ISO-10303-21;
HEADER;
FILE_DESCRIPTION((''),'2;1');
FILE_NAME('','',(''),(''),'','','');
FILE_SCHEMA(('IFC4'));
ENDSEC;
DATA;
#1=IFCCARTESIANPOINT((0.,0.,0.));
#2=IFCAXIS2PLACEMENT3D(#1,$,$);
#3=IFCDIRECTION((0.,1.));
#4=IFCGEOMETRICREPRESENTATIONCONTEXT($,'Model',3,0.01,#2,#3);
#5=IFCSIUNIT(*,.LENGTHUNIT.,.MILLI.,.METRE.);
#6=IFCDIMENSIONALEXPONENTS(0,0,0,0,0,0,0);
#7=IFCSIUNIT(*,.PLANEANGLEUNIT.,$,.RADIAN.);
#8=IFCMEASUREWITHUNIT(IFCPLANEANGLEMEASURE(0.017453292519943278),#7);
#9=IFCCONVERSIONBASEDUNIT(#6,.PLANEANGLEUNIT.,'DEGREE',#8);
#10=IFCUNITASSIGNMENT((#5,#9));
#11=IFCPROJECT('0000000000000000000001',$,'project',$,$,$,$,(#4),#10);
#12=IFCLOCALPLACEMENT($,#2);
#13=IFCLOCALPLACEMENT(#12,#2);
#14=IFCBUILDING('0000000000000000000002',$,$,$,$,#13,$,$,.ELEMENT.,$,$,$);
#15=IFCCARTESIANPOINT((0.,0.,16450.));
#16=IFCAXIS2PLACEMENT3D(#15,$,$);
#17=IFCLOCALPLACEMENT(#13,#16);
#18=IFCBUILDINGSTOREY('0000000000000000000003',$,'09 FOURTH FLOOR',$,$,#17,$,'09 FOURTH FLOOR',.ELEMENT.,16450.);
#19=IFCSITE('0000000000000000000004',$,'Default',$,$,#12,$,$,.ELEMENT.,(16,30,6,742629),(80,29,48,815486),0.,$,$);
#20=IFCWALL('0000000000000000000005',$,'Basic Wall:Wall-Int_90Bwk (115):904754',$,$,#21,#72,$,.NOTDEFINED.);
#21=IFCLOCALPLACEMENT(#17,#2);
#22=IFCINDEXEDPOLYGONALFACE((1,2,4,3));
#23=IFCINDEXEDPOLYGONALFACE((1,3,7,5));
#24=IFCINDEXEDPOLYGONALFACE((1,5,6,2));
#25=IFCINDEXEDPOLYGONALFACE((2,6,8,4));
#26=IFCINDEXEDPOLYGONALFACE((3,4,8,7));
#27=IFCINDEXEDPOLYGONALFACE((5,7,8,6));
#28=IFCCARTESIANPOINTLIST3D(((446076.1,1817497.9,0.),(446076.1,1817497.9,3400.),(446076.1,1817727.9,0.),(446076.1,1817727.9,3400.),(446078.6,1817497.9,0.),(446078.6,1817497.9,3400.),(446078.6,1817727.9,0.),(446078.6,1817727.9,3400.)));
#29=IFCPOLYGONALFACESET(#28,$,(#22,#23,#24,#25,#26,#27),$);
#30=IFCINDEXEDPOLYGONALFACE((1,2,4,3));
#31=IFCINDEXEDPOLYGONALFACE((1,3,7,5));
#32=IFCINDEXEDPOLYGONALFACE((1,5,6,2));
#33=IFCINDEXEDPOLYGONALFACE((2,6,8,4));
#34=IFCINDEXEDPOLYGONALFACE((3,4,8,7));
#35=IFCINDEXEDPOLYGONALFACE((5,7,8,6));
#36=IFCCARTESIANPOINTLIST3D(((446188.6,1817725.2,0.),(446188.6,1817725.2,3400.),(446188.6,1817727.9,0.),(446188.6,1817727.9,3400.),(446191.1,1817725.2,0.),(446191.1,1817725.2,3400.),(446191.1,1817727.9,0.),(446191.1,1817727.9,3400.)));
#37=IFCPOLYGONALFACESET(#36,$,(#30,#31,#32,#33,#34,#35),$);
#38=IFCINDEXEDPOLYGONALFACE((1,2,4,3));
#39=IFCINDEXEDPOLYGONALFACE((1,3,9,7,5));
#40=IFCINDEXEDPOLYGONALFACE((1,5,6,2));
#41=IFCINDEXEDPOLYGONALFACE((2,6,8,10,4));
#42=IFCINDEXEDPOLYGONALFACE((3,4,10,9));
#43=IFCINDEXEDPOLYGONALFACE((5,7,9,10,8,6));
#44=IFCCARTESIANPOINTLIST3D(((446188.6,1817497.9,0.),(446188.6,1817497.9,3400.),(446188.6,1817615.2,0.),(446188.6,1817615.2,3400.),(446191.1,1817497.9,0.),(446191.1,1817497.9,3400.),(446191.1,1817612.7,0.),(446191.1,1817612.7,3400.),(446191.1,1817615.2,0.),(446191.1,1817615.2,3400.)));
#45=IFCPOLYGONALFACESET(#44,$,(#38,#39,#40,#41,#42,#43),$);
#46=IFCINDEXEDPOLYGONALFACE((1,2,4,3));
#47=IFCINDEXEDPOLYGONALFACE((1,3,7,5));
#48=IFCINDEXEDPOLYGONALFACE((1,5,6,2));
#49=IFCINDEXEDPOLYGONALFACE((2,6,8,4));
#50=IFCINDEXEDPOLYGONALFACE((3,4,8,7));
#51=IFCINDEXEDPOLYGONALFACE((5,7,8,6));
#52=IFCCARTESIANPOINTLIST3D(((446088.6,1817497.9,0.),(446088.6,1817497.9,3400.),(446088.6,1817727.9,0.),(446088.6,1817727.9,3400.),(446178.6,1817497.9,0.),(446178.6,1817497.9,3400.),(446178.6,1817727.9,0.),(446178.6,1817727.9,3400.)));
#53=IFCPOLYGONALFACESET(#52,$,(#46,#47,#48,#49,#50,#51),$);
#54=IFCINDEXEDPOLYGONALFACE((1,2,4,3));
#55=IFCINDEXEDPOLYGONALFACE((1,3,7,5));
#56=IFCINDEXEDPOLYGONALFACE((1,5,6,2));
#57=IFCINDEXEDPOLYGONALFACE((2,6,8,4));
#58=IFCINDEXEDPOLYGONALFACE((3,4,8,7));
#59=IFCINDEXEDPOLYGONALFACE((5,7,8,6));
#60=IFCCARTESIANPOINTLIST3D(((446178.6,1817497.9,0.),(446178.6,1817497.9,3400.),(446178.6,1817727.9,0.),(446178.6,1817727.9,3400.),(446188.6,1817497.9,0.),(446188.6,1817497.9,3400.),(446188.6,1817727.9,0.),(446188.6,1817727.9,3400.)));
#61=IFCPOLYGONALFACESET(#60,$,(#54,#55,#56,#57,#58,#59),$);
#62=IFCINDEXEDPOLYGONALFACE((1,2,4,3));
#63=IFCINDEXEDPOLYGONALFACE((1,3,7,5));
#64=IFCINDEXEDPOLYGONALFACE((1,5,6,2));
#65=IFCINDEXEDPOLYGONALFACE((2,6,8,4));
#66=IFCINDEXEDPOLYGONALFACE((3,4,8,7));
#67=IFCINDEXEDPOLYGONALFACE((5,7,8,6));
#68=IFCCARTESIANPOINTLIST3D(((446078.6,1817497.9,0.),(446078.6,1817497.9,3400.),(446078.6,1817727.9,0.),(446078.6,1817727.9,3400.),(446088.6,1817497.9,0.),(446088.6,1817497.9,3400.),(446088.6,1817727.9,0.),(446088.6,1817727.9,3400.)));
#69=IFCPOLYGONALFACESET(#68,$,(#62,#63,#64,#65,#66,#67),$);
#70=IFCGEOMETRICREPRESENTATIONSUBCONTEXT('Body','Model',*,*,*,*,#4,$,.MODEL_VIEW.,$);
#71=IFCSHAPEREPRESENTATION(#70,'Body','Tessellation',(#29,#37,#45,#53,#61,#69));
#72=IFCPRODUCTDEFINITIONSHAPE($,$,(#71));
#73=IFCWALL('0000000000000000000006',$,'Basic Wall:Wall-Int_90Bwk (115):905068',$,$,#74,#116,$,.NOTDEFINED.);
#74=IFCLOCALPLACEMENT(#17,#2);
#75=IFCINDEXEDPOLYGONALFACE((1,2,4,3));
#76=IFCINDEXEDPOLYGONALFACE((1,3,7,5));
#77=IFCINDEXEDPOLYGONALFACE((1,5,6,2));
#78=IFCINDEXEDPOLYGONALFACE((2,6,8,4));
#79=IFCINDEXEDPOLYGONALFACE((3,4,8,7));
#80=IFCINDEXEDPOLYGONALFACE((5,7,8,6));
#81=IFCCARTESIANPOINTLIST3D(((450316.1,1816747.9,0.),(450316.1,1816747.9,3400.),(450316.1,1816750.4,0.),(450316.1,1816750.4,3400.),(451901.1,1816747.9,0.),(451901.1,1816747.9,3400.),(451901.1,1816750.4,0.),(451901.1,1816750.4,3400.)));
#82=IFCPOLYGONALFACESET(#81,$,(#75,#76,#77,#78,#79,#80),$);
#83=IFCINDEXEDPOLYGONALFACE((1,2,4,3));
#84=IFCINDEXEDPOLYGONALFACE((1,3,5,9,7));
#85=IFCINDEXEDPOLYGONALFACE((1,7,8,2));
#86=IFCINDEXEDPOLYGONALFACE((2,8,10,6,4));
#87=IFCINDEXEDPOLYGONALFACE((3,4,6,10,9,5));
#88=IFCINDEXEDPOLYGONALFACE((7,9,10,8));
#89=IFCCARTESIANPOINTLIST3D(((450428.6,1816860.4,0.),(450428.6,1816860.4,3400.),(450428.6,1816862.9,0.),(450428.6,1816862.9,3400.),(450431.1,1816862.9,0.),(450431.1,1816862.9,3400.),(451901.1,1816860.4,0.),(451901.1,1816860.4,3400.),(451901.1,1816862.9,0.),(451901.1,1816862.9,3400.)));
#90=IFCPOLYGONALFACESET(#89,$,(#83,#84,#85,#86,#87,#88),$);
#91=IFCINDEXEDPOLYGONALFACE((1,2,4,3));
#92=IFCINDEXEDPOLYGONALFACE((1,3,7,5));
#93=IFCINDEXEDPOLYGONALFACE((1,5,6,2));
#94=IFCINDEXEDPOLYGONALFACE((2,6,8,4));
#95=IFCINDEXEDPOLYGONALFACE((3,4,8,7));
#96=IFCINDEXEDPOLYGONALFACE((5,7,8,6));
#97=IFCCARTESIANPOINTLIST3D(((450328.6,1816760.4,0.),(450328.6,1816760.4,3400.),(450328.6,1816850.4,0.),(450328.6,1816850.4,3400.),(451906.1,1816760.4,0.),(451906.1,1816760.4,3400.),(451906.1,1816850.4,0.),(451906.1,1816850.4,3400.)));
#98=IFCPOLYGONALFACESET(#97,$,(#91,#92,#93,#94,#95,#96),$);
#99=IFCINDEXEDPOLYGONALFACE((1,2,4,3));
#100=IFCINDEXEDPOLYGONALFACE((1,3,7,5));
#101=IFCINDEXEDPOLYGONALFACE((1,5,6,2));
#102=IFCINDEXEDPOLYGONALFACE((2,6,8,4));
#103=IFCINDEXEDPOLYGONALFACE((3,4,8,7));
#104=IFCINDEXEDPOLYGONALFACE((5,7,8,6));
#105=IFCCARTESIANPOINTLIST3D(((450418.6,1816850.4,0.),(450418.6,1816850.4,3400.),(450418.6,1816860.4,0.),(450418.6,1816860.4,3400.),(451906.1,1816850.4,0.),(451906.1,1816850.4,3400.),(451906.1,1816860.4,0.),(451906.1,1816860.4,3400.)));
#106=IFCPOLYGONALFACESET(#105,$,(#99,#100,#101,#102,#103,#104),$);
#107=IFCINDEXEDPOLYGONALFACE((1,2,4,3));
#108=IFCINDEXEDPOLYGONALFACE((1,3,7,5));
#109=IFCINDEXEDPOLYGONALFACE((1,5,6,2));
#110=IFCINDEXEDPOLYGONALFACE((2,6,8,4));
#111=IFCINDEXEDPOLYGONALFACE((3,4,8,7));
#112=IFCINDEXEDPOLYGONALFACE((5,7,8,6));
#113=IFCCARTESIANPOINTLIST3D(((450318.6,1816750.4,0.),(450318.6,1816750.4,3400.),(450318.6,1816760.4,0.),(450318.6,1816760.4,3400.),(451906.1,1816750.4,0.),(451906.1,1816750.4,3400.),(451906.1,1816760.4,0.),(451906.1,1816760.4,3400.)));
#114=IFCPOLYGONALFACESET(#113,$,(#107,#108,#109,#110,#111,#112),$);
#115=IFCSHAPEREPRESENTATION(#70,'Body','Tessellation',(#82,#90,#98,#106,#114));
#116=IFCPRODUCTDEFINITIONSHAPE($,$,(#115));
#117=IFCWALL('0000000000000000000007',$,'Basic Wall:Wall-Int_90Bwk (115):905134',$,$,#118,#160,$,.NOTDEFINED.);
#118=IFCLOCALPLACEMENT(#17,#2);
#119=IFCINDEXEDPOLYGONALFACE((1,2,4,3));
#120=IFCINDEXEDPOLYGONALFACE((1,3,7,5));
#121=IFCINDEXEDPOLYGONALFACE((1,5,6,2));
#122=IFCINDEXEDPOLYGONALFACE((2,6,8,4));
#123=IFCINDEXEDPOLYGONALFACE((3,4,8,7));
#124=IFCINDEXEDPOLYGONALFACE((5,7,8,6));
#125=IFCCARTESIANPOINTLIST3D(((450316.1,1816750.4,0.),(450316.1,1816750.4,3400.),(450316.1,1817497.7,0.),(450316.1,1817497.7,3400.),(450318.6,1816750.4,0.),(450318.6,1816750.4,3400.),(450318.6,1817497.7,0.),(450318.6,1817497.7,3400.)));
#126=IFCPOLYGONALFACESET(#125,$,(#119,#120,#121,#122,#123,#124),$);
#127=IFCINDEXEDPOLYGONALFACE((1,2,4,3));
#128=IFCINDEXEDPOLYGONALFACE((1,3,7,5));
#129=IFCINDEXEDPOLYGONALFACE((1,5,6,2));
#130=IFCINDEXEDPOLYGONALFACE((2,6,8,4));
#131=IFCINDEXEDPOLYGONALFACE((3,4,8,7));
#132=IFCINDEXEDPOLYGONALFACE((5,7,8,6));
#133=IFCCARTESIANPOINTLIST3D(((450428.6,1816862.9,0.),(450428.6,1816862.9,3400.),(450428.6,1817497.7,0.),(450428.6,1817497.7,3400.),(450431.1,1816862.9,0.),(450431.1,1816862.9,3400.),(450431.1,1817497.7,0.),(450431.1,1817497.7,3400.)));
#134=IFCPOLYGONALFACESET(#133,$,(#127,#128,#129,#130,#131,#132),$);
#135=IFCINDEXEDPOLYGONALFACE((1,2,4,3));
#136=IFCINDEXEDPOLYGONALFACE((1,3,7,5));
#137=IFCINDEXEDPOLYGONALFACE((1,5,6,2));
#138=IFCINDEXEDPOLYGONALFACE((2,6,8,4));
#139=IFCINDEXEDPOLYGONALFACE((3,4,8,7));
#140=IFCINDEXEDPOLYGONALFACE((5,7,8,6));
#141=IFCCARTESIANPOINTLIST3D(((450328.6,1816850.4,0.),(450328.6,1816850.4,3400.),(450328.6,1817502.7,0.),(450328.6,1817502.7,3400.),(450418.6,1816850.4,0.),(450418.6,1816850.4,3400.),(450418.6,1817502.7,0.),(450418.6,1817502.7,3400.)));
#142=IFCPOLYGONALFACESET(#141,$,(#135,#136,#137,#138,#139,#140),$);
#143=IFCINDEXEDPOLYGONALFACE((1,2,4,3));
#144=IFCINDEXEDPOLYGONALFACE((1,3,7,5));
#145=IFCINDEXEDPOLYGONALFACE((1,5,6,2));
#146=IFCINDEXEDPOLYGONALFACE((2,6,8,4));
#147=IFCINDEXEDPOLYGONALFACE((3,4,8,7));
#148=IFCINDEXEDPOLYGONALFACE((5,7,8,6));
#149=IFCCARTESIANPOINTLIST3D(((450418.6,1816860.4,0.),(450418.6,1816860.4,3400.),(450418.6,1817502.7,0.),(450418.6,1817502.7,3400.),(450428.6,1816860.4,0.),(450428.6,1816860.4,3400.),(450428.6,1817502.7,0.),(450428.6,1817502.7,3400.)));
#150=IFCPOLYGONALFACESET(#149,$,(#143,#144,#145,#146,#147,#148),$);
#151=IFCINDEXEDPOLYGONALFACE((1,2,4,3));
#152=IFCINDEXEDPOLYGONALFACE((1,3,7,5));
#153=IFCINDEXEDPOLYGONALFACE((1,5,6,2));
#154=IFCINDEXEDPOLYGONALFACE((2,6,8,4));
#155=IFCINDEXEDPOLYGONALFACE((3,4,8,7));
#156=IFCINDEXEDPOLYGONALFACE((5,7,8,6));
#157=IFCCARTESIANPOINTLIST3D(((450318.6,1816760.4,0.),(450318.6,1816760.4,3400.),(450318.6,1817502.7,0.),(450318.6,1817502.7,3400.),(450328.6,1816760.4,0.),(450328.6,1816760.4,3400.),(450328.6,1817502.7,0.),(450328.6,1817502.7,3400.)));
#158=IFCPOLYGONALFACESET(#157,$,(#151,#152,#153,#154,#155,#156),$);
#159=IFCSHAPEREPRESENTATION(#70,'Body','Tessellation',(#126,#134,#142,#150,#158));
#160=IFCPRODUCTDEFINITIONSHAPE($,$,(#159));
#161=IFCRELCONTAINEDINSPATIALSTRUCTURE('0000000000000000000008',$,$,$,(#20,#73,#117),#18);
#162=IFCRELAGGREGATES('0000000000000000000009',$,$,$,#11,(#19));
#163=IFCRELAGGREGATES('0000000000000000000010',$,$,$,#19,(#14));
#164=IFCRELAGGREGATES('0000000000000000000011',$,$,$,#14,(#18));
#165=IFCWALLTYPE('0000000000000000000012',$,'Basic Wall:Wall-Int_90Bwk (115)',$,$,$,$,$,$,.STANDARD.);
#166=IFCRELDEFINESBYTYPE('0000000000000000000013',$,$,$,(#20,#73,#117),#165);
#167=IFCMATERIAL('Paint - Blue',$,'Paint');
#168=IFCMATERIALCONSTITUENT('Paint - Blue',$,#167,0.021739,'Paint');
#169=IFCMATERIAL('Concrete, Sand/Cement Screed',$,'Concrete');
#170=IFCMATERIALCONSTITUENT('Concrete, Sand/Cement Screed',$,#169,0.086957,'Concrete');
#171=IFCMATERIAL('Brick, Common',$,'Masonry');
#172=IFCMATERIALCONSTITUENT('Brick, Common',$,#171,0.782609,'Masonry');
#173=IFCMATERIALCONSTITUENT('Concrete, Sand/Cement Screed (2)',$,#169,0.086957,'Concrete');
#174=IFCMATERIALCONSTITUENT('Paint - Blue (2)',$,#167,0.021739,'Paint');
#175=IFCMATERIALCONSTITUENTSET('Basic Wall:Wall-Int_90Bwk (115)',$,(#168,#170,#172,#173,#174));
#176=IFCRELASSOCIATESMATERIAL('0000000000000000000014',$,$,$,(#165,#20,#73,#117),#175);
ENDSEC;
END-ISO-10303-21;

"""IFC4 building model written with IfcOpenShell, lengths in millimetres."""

from ifc_helpers import new_model, entity, si_unit, converted_unit, direction, frame, origin, place, context, subcontext, project, spatial, indexed_curve, outline, extrude, material, constituent, constituent_set, type_object, element, save


model = new_model("IFC4")

# Units and contexts
model_context = context("Model", 3, precision=0.01, world=origin(), true_north=direction((0.0, 1.0)))
body_context = subcontext(model_context, "Body", "Model", "MODEL_VIEW")
ifc_project = project(units=[si_unit("LENGTHUNIT", "METRE", prefix="MILLI"), converted_unit("PLANEANGLEUNIT", "DEGREE", entity("IfcPlaneAngleMeasure", 0.017453292519943278), si_unit("PLANEANGLEUNIT", "RADIAN"), dimensions=[0, 0, 0, 0, 0, 0, 0])], contexts=[model_context])

# Site, building, storey
site_placement = place(None, origin())
site = spatial("IfcSite", under=ifc_project, at=site_placement, Name="Default", CompositionType="ELEMENT", RefLatitude=(16, 30, 6, 742629), RefLongitude=(80, 29, 48, 815486), RefElevation=0.0)
building_placement = place(site_placement, origin())
building = spatial("IfcBuilding", under=site, at=building_placement, CompositionType="ELEMENT")
storey_placement = place(building_placement, frame((0.0, 0.0, 16450.0)))
storey = spatial("IfcBuildingStorey", under=building, at=storey_placement, Name="09 FOURTH FLOOR", LongName="09 FOURTH FLOOR", CompositionType="ELEMENT", Elevation=16450.0)

# Shared definitions
ifc_material_1 = material(Name="Paint - Blue", Category="Paint")
ifc_constituent_1 = constituent(ifc_material_1, Name="Paint - Blue", Category="Paint", fraction=0.021739)
ifc_material_2 = material(Name="Concrete, Sand/Cement Screed", Category="Concrete")
ifc_constituent_2 = constituent(ifc_material_2, Name="Concrete, Sand/Cement Screed", Category="Concrete", fraction=0.086957)
ifc_material_3 = material(Name="Brick, Common", Category="Masonry")
ifc_constituent_3 = constituent(ifc_material_3, Name="Brick, Common", Category="Masonry", fraction=0.782609)
ifc_constituent_4 = constituent(ifc_material_2, Name="Concrete, Sand/Cement Screed (2)", Category="Concrete", fraction=0.086957)
ifc_constituent_5 = constituent(ifc_material_1, Name="Paint - Blue (2)", Category="Paint", fraction=0.021739)
ifc_constituent_set_1 = constituent_set(constituents=[ifc_constituent_1, ifc_constituent_2, ifc_constituent_3, ifc_constituent_4, ifc_constituent_5], Name="Basic Wall:Wall-Int_90Bwk (115)")
wall_type_1 = type_object("IfcWallType", Name="Basic Wall:Wall-Int_90Bwk (115)", PredefinedType="STANDARD", material=ifc_constituent_set_1)

# Walls
wall_1_placement = place(storey_placement, frame((446133.6, 1817497.9, 0.0), z_axis=(0.0, 0.0, 1.0), x_axis=(0.0, 1.0, 0.0)))
element("IfcWall", 1, at=wall_1_placement, inside=storey, type_object=wall_type_1, material=ifc_constituent_set_1, Name="Basic Wall:Wall-Int_90Bwk (115):904754", PredefinedType="NOTDEFINED", context=body_context, shape_type="SweptSolid", body=[
    extrude(outline(indexed_curve([(-1.2, -115.0), (1.3, -115.0), (1.3, 115.0), (-1.2, 115.0), (-1.2, -115.0)], self_intersect=False)), frame((115.0, 56.3, 0.0), z_axis=(0.0, 0.0, 1.0), x_axis=(0.0, -1.0, 0.0)), (0.0, 0.0, 1.0), 3400.0),
    extrude(outline(indexed_curve([(-1.3, -1.3), (1.3, -1.3), (1.3, 1.2), (-1.3, 1.2), (-1.3, -1.3)], self_intersect=False)), frame((228.7, -56.3, 0.0), z_axis=(0.0, 0.0, 1.0), x_axis=(-1.0, 0.0, 0.0)), (0.0, 0.0, 1.0), 3400.0),
    extrude(outline(indexed_curve([(44.9, -1.0), (47.4, -1.0), (47.4, 1.5), (-69.9, 1.5), (-69.9, -1.0), (44.9, -1.0)], self_intersect=False)), frame((69.9, -56.5, 0.0)), (0.0, 0.0, 1.0), 3400.0),
    extrude(outline(indexed_curve([(-115.0, -45.0), (115.0, -45.0), (115.0, 45.0), (-115.0, 45.0), (-115.0, -45.0)], self_intersect=False)), frame((115.0, 0.0, 0.0)), (0.0, 0.0, 1.0), 3400.0),
    extrude(outline(indexed_curve([(-115.0, -5.0), (115.0, -5.0), (115.0, 5.0), (-115.0, 5.0), (-115.0, -5.0)], self_intersect=False)), frame((115.0, -50.0, 0.0)), (0.0, 0.0, 1.0), 3400.0),
    extrude(outline(indexed_curve([(-115.0, -5.0), (115.0, -5.0), (115.0, 5.0), (-115.0, 5.0), (-115.0, -5.0)], self_intersect=False)), frame((115.0, 50.0, 0.0)), (0.0, 0.0, 1.0), 3400.0),
])
wall_2_placement = place(storey_placement, frame((451901.1, 1816805.4, 0.0), z_axis=(0.0, 0.0, 1.0), x_axis=(-1.0, 0.0, 0.0)))
element("IfcWall", 2, at=wall_2_placement, inside=storey, type_object=wall_type_1, material=ifc_constituent_set_1, Name="Basic Wall:Wall-Int_90Bwk (115):905068", PredefinedType="NOTDEFINED", context=body_context, shape_type="SweptSolid", body=[
    extrude(outline(indexed_curve([(-1.3, -792.5), (1.3, -792.5), (1.3, 792.5), (-1.3, 792.5), (-1.3, -792.5)], self_intersect=False)), frame((792.5, 56.3, 0.0), z_axis=(0.0, 0.0, 1.0), x_axis=(0.0, -1.0, 0.0)), (0.0, 0.0, 1.0), 3400.0),
    extrude(outline(indexed_curve([(587.0, -1.0), (589.5, -1.0), (589.5, 1.5), (-883.0, 1.5), (-883.0, -1.0), (587.0, -1.0)], self_intersect=False)), frame((883.0, -56.5, 0.0)), (0.0, 0.0, 1.0), 3400.0),
    extrude(outline(indexed_curve([(-788.8, -45.0), (788.8, -45.0), (788.8, 45.0), (-788.8, 45.0), (-788.8, -45.0)], self_intersect=False)), frame((783.8, 0.0, 0.0)), (0.0, 0.0, 1.0), 3400.0),
    extrude(outline(indexed_curve([(-743.8, -5.0), (743.8, -5.0), (743.8, 5.0), (-743.8, 5.0), (-743.8, -5.0)], self_intersect=False)), frame((738.8, -50.0, 0.0)), (0.0, 0.0, 1.0), 3400.0),
    extrude(outline(indexed_curve([(-793.8, -5.0), (793.8, -5.0), (793.8, 5.0), (-793.8, 5.0), (-793.8, -5.0)], self_intersect=False)), frame((788.8, 50.0, 0.0)), (0.0, 0.0, 1.0), 3400.0),
])
wall_3_placement = place(storey_placement, frame((450373.6, 1816862.9, 0.0), z_axis=(0.0, 0.0, 1.0), x_axis=(0.0, 1.0, 0.0)))
element("IfcWall", 3, at=wall_3_placement, inside=storey, type_object=wall_type_1, material=ifc_constituent_set_1, Name="Basic Wall:Wall-Int_90Bwk (115):905134", PredefinedType="NOTDEFINED", context=body_context, shape_type="SweptSolid", body=[
    extrude(outline(indexed_curve([(-1.3, -373.7), (1.2, -373.7), (1.2, 373.7), (-1.3, 373.7), (-1.3, -373.7)], self_intersect=False)), frame((261.2, 56.2, 0.0), z_axis=(0.0, 0.0, 1.0), x_axis=(0.0, -1.0, 0.0)), (0.0, 0.0, 1.0), 3400.0),
    extrude(outline(indexed_curve([(-1.3, -317.4), (1.2, -317.4), (1.2, 317.4), (-1.3, 317.4), (-1.3, -317.4)], self_intersect=False)), frame((317.4, -56.2, 0.0), z_axis=(0.0, 0.0, 1.0), x_axis=(0.0, 1.0, 0.0)), (0.0, 0.0, 1.0), 3400.0),
    extrude(outline(indexed_curve([(-326.2, -45.0), (326.2, -45.0), (326.2, 45.0), (-326.2, 45.0), (-326.2, -45.0)], self_intersect=False)), frame((313.7, 0.0, 0.0)), (0.0, 0.0, 1.0), 3400.0),
    extrude(outline(indexed_curve([(-321.2, -5.0), (321.2, -5.0), (321.2, 5.0), (-321.2, 5.0), (-321.2, -5.0)], self_intersect=False)), frame((318.7, -50.0, 0.0)), (0.0, 0.0, 1.0), 3400.0),
    extrude(outline(indexed_curve([(-371.2, -5.0), (371.2, -5.0), (371.2, 5.0), (-371.2, 5.0), (-371.2, -5.0)], self_intersect=False)), frame((268.7, 50.0, 0.0)), (0.0, 0.0, 1.0), 3400.0),
])

save(model, "model.ifc")
